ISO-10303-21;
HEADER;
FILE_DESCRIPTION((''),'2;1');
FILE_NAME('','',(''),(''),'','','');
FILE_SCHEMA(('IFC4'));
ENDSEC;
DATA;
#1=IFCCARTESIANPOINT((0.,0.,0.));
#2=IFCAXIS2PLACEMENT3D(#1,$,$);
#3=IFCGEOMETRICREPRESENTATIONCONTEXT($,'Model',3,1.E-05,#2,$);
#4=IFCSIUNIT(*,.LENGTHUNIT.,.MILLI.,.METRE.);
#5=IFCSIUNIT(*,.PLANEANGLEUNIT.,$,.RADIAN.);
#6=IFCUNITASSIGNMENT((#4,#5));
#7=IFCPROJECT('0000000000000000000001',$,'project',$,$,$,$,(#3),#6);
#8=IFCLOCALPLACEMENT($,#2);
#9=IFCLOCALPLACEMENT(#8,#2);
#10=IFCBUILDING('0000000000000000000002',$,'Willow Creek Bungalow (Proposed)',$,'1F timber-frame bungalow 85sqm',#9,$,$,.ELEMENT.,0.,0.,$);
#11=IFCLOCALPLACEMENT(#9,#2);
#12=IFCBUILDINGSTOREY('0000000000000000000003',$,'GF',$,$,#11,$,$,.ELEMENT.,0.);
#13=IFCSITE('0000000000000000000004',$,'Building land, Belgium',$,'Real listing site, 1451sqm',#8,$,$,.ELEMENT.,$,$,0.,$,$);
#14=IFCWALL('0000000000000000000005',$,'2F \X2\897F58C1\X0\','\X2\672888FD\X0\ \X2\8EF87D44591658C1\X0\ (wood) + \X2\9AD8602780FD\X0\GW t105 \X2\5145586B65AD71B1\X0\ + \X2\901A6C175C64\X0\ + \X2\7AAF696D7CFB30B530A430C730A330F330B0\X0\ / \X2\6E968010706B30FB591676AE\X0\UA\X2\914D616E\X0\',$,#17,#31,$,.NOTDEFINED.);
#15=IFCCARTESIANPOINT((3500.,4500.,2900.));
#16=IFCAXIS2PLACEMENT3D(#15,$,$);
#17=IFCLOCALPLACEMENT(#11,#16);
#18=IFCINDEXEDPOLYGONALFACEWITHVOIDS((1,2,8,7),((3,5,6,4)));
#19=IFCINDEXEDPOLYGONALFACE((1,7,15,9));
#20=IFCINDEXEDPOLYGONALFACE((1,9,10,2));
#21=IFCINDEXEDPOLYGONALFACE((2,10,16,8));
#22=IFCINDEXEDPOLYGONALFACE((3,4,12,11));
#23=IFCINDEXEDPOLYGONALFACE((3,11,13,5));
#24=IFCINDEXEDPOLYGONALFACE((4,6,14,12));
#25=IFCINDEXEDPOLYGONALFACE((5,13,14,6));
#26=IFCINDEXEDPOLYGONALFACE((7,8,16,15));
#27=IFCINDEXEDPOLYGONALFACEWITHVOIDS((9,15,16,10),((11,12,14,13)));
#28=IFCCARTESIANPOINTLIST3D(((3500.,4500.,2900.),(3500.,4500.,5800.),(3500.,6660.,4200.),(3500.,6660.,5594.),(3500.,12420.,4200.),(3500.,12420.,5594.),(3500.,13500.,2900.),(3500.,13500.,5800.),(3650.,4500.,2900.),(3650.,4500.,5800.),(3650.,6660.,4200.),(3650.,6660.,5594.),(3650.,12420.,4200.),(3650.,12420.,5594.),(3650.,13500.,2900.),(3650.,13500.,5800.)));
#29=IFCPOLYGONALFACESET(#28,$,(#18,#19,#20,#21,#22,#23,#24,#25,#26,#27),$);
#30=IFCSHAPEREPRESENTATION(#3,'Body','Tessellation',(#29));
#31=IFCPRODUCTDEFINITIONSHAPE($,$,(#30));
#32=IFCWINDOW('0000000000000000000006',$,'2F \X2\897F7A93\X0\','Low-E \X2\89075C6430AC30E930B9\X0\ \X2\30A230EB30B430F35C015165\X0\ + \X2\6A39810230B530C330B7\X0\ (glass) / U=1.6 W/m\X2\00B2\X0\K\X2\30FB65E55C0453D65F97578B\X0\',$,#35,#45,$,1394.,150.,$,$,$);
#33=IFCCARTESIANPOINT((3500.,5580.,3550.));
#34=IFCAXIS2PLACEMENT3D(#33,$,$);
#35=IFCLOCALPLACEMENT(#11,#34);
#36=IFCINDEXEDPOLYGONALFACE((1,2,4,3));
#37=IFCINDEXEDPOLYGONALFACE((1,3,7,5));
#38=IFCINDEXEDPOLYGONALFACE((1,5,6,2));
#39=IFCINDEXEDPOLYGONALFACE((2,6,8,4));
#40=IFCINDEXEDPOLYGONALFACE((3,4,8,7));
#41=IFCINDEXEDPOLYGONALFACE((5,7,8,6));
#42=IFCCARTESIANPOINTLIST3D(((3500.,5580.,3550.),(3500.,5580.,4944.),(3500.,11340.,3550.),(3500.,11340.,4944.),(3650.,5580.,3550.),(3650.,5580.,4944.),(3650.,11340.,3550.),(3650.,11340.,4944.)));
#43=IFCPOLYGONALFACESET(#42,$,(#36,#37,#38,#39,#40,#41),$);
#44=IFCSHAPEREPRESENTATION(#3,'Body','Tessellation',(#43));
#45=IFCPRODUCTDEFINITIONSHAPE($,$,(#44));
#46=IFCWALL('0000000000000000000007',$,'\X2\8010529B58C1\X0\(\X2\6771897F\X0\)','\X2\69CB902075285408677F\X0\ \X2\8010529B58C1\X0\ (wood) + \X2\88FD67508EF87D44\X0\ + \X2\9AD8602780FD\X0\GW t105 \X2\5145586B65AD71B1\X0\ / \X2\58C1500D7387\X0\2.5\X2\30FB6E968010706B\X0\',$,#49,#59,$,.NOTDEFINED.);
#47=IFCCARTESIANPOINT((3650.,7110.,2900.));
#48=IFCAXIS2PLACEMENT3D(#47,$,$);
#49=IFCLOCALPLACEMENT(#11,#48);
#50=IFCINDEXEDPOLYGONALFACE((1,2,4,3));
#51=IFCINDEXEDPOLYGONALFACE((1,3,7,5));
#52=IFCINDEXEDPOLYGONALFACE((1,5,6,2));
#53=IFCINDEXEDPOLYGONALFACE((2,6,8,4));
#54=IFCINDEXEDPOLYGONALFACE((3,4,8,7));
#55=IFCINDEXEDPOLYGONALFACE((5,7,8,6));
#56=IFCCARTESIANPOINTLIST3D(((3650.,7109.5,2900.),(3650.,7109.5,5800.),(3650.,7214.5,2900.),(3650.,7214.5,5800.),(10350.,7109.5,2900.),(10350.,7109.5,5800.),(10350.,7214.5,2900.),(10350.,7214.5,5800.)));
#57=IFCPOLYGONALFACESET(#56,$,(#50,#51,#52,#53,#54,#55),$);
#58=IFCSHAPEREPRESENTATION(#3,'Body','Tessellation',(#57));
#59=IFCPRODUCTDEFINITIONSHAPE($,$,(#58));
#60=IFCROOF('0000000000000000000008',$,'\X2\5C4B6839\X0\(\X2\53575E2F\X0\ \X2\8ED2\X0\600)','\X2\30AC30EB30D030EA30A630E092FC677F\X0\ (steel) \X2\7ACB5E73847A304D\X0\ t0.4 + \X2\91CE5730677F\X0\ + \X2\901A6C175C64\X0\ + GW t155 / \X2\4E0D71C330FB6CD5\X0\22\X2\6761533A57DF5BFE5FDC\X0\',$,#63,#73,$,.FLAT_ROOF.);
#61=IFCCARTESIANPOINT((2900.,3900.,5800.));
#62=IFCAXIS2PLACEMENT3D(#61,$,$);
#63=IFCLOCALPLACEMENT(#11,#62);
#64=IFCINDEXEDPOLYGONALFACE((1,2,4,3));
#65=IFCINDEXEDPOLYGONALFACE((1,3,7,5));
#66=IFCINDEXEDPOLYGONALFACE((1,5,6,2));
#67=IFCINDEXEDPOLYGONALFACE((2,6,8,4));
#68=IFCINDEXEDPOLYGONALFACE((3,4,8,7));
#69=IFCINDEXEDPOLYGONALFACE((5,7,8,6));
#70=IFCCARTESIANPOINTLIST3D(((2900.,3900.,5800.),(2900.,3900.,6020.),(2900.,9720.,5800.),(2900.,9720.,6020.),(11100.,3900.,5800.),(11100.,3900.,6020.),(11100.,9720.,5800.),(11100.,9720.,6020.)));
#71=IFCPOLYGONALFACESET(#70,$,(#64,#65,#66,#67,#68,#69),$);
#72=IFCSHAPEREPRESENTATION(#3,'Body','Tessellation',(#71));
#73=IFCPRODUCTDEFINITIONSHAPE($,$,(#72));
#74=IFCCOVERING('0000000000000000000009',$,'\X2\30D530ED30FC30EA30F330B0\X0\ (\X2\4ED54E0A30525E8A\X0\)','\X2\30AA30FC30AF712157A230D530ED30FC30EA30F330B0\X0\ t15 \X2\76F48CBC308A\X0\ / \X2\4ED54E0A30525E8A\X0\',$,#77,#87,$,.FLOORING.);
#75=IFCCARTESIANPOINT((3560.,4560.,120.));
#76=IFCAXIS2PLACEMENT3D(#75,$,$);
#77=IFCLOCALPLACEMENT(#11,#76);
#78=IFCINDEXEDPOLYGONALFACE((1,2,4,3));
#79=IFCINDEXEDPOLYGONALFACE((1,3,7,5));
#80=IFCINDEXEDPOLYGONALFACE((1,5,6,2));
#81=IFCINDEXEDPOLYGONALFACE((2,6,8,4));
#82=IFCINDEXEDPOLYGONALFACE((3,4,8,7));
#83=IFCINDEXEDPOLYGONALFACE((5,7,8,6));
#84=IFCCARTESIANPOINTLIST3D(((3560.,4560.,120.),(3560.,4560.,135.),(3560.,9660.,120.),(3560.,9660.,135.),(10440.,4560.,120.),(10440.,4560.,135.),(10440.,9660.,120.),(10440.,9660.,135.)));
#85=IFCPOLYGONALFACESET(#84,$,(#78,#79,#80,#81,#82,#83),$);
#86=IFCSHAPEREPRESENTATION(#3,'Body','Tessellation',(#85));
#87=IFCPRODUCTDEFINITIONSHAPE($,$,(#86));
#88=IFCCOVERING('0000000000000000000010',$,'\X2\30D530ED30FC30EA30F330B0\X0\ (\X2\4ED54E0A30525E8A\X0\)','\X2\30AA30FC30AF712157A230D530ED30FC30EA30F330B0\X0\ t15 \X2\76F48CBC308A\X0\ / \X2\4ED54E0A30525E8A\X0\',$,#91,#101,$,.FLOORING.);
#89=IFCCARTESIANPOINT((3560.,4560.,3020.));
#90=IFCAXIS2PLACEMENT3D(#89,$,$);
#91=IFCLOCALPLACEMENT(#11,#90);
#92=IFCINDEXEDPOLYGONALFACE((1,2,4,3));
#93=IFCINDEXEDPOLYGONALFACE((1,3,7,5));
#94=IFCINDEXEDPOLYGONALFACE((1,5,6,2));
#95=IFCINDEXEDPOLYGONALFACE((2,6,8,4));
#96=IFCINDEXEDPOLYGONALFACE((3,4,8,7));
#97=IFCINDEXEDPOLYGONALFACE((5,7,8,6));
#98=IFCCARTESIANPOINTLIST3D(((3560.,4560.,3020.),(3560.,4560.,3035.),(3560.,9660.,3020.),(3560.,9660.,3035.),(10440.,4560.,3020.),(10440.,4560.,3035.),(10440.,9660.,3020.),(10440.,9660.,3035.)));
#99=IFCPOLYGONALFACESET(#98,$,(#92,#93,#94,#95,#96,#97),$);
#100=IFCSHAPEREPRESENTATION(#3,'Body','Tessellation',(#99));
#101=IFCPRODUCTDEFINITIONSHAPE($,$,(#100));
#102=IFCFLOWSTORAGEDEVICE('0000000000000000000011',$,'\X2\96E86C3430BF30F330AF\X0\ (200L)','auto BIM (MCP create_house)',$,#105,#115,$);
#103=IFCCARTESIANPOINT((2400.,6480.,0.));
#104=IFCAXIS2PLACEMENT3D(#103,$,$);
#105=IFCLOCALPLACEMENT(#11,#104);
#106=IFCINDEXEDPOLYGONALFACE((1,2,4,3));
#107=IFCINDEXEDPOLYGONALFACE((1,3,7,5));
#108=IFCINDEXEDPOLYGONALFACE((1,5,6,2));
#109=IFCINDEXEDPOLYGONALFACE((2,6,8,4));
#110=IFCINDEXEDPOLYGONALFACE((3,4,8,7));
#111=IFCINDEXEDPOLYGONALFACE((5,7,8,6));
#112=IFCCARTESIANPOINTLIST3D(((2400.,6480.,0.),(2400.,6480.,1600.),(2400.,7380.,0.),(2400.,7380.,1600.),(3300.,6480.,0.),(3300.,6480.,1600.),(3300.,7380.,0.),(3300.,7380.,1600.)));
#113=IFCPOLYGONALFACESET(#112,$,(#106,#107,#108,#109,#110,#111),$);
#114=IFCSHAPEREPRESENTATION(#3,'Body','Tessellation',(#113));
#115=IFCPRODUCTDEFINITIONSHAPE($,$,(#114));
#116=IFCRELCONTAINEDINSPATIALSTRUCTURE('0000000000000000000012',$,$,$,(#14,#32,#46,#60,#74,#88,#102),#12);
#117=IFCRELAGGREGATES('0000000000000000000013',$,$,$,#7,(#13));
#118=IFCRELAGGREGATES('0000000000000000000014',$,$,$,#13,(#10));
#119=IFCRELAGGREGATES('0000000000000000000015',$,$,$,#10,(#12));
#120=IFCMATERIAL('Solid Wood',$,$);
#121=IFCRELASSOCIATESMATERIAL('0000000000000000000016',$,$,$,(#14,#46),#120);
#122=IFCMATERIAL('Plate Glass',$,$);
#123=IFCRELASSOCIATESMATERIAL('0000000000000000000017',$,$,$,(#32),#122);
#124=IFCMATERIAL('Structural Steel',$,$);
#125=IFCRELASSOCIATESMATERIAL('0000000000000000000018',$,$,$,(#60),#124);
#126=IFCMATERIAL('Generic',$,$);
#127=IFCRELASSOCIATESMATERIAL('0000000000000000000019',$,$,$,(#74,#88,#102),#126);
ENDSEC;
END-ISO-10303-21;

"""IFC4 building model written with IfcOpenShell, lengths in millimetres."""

from ifc_helpers import new_model, si_unit, frame, frame_2d, origin, place, context, project, spatial, rectangle, extrude, material, element, fill, save


model = new_model("IFC4")

# Units and contexts
model_context = context("Model", 3, precision=1e-05, world=origin())
ifc_project = project(units=[si_unit("LENGTHUNIT", "METRE", prefix="MILLI"), si_unit("PLANEANGLEUNIT", "RADIAN")], contexts=[model_context])

# Site, building, storey
site_placement = place(None, origin())
site = spatial("IfcSite", under=ifc_project, at=site_placement, Name="Building land, Belgium", ObjectType="Real listing site, 1451sqm", CompositionType="ELEMENT", RefElevation=0.0)
building_placement = place(site_placement, origin())
building = spatial("IfcBuilding", under=site, at=building_placement, Name="Willow Creek Bungalow (Proposed)", ObjectType="1F timber-frame bungalow 85sqm", CompositionType="ELEMENT", ElevationOfRefHeight=0.0, ElevationOfTerrain=0.0)
storey_placement = place(building_placement, origin())
storey = spatial("IfcBuildingStorey", under=building, at=storey_placement, Name="GF", CompositionType="ELEMENT", Elevation=0.0)

# Shared definitions
ifc_material_1 = material(Name="Solid Wood")
ifc_material_2 = material(Name="Generic")

# Shared definitions
ifc_material_3 = material(Name="Plate Glass")

# Wall, opening, window
wall_1_placement = place(storey_placement, frame((3500.0, 4500.0, 2900.0)))
wall_1 = element("IfcWall", 1, at=wall_1_placement, inside=storey, material=ifc_material_1, Name="2F 西壁", Description="木製 軸組外壁 (wood) + 高性能GW t105 充填断熱 + 通気層 + 窯業系サイディング / 準耐火・外皮UA配慮", PredefinedType="NOTDEFINED", context=model_context, shape_type="SweptSolid", body=[
    extrude(rectangle(XDim=150.0, YDim=9000.0, at=frame_2d((75.0, 4500.0))), frame((3500.0, 4500.0, 2900.0)), (0.0, 0.0, 1.0), 2900.0),
])
opening_1_placement = place(storey_placement, frame((3500.0, 5580.0, 3550.0)))
opening_1 = element("IfcOpeningElement", 2, at=opening_1_placement, cuts=wall_1, PredefinedType="NOTDEFINED", context=model_context, shape_type="SweptSolid", body=[
    extrude(rectangle(XDim=150.0, YDim=5760.0, at=frame_2d((75.0, 2880.0))), frame((3500.0, 5580.0, 3550.0)), (0.0, 0.0, 1.0), 1394.0),
])
window_1_placement = place(storey_placement, frame((3500.0, 5580.0, 3550.0)))
window_1 = element("IfcWindow", 3, at=window_1_placement, inside=storey, material=ifc_material_3, Name="2F 西窓", Description="Low-E 複層ガラス アルゴン封入 + 樹脂サッシ (glass) / U=1.6 W/m²K・日射取得型", OverallHeight=1394.0, OverallWidth=150.0, context=model_context, shape_type="SweptSolid", body=[
    extrude(rectangle(XDim=150.0, YDim=5760.0, at=frame_2d((75.0, 2880.0))), frame((3500.0, 5580.0, 3550.0)), (0.0, 0.0, 1.0), 1394.0),
])
fill(opening_1, window_1)

# Wall
wall_2_placement = place(storey_placement, frame((3650.0, 7110.0, 2900.0)))
element("IfcWall", 4, at=wall_2_placement, inside=storey, material=ifc_material_1, Name="耐力壁(東西)", Description="構造用合板 耐力壁 (wood) + 製材軸組 + 高性能GW t105 充填断熱 / 壁倍率2.5・準耐火", PredefinedType="NOTDEFINED", context=model_context, shape_type="SweptSolid", body=[
    extrude(rectangle(XDim=6700.0, YDim=105.0, at=frame_2d((3350.0, 52.0))), frame((3650.0, 7110.0, 2900.0)), (0.0, 0.0, 1.0), 2900.0),
])

# Roof
ifc_material_4 = material(Name="Structural Steel")
for number, where, name in (
    (5, (2900.0, 3900.0, 5800.0), "屋根(南帯 軒600)"),
):
    element("IfcRoof", number, at=place(storey_placement, frame(where)), inside=storey, material=ifc_material_4, Name=name, Description="ガルバリウム鋼板 (steel) 立平葺き t0.4 + 野地板 + 通気層 + GW t155 / 不燃・法22条区域対応", PredefinedType="FLAT_ROOF", context=model_context, shape_type="SweptSolid", body=[
        extrude(rectangle(XDim=8200.0, YDim=5820.0, at=frame_2d((4100.0, 2910.0))), frame((2900.0, 3900.0, 5800.0)), (0.0, 0.0, 1.0), 220.0),
    ])

# Coverings
covering_1_placement = place(storey_placement, frame((3560.0, 4560.0, 120.0)))
element("IfcCovering", 6, at=covering_1_placement, inside=storey, material=ifc_material_2, Name="フローリング (仕上げ床)", Description="オーク無垢フローリング t15 直貼り / 仕上げ床", PredefinedType="FLOORING", context=model_context, shape_type="SweptSolid", body=[
    extrude(rectangle(XDim=6880.0, YDim=5100.0, at=frame_2d((3440.0, 2550.0))), frame((3560.0, 4560.0, 120.0)), (0.0, 0.0, 1.0), 15.0),
])
covering_2_placement = place(storey_placement, frame((3560.0, 4560.0, 3020.0)))
element("IfcCovering", 7, at=covering_2_placement, inside=storey, material=ifc_material_2, Name="フローリング (仕上げ床)", Description="オーク無垢フローリング t15 直貼り / 仕上げ床", PredefinedType="FLOORING", context=model_context, shape_type="SweptSolid", body=[
    extrude(rectangle(XDim=6880.0, YDim=5100.0, at=frame_2d((3440.0, 2550.0))), frame((3560.0, 4560.0, 3020.0)), (0.0, 0.0, 1.0), 15.0),
])

# Flow storage device
flow_storage_device_placement = place(storey_placement, frame((2400.0, 6480.0, 0.0)))
element("IfcFlowStorageDevice", 8, at=flow_storage_device_placement, inside=storey, material=ifc_material_2, Name="雨水タンク (200L)", Description="auto BIM (MCP create_house)", context=model_context, shape_type="SweptSolid", body=[
    extrude(rectangle(XDim=900.0, YDim=900.0, at=frame_2d((450.0, 450.0))), frame((2400.0, 6480.0, 0.0)), (0.0, 0.0, 1.0), 1600.0),
])

save(model, "model.ifc")
